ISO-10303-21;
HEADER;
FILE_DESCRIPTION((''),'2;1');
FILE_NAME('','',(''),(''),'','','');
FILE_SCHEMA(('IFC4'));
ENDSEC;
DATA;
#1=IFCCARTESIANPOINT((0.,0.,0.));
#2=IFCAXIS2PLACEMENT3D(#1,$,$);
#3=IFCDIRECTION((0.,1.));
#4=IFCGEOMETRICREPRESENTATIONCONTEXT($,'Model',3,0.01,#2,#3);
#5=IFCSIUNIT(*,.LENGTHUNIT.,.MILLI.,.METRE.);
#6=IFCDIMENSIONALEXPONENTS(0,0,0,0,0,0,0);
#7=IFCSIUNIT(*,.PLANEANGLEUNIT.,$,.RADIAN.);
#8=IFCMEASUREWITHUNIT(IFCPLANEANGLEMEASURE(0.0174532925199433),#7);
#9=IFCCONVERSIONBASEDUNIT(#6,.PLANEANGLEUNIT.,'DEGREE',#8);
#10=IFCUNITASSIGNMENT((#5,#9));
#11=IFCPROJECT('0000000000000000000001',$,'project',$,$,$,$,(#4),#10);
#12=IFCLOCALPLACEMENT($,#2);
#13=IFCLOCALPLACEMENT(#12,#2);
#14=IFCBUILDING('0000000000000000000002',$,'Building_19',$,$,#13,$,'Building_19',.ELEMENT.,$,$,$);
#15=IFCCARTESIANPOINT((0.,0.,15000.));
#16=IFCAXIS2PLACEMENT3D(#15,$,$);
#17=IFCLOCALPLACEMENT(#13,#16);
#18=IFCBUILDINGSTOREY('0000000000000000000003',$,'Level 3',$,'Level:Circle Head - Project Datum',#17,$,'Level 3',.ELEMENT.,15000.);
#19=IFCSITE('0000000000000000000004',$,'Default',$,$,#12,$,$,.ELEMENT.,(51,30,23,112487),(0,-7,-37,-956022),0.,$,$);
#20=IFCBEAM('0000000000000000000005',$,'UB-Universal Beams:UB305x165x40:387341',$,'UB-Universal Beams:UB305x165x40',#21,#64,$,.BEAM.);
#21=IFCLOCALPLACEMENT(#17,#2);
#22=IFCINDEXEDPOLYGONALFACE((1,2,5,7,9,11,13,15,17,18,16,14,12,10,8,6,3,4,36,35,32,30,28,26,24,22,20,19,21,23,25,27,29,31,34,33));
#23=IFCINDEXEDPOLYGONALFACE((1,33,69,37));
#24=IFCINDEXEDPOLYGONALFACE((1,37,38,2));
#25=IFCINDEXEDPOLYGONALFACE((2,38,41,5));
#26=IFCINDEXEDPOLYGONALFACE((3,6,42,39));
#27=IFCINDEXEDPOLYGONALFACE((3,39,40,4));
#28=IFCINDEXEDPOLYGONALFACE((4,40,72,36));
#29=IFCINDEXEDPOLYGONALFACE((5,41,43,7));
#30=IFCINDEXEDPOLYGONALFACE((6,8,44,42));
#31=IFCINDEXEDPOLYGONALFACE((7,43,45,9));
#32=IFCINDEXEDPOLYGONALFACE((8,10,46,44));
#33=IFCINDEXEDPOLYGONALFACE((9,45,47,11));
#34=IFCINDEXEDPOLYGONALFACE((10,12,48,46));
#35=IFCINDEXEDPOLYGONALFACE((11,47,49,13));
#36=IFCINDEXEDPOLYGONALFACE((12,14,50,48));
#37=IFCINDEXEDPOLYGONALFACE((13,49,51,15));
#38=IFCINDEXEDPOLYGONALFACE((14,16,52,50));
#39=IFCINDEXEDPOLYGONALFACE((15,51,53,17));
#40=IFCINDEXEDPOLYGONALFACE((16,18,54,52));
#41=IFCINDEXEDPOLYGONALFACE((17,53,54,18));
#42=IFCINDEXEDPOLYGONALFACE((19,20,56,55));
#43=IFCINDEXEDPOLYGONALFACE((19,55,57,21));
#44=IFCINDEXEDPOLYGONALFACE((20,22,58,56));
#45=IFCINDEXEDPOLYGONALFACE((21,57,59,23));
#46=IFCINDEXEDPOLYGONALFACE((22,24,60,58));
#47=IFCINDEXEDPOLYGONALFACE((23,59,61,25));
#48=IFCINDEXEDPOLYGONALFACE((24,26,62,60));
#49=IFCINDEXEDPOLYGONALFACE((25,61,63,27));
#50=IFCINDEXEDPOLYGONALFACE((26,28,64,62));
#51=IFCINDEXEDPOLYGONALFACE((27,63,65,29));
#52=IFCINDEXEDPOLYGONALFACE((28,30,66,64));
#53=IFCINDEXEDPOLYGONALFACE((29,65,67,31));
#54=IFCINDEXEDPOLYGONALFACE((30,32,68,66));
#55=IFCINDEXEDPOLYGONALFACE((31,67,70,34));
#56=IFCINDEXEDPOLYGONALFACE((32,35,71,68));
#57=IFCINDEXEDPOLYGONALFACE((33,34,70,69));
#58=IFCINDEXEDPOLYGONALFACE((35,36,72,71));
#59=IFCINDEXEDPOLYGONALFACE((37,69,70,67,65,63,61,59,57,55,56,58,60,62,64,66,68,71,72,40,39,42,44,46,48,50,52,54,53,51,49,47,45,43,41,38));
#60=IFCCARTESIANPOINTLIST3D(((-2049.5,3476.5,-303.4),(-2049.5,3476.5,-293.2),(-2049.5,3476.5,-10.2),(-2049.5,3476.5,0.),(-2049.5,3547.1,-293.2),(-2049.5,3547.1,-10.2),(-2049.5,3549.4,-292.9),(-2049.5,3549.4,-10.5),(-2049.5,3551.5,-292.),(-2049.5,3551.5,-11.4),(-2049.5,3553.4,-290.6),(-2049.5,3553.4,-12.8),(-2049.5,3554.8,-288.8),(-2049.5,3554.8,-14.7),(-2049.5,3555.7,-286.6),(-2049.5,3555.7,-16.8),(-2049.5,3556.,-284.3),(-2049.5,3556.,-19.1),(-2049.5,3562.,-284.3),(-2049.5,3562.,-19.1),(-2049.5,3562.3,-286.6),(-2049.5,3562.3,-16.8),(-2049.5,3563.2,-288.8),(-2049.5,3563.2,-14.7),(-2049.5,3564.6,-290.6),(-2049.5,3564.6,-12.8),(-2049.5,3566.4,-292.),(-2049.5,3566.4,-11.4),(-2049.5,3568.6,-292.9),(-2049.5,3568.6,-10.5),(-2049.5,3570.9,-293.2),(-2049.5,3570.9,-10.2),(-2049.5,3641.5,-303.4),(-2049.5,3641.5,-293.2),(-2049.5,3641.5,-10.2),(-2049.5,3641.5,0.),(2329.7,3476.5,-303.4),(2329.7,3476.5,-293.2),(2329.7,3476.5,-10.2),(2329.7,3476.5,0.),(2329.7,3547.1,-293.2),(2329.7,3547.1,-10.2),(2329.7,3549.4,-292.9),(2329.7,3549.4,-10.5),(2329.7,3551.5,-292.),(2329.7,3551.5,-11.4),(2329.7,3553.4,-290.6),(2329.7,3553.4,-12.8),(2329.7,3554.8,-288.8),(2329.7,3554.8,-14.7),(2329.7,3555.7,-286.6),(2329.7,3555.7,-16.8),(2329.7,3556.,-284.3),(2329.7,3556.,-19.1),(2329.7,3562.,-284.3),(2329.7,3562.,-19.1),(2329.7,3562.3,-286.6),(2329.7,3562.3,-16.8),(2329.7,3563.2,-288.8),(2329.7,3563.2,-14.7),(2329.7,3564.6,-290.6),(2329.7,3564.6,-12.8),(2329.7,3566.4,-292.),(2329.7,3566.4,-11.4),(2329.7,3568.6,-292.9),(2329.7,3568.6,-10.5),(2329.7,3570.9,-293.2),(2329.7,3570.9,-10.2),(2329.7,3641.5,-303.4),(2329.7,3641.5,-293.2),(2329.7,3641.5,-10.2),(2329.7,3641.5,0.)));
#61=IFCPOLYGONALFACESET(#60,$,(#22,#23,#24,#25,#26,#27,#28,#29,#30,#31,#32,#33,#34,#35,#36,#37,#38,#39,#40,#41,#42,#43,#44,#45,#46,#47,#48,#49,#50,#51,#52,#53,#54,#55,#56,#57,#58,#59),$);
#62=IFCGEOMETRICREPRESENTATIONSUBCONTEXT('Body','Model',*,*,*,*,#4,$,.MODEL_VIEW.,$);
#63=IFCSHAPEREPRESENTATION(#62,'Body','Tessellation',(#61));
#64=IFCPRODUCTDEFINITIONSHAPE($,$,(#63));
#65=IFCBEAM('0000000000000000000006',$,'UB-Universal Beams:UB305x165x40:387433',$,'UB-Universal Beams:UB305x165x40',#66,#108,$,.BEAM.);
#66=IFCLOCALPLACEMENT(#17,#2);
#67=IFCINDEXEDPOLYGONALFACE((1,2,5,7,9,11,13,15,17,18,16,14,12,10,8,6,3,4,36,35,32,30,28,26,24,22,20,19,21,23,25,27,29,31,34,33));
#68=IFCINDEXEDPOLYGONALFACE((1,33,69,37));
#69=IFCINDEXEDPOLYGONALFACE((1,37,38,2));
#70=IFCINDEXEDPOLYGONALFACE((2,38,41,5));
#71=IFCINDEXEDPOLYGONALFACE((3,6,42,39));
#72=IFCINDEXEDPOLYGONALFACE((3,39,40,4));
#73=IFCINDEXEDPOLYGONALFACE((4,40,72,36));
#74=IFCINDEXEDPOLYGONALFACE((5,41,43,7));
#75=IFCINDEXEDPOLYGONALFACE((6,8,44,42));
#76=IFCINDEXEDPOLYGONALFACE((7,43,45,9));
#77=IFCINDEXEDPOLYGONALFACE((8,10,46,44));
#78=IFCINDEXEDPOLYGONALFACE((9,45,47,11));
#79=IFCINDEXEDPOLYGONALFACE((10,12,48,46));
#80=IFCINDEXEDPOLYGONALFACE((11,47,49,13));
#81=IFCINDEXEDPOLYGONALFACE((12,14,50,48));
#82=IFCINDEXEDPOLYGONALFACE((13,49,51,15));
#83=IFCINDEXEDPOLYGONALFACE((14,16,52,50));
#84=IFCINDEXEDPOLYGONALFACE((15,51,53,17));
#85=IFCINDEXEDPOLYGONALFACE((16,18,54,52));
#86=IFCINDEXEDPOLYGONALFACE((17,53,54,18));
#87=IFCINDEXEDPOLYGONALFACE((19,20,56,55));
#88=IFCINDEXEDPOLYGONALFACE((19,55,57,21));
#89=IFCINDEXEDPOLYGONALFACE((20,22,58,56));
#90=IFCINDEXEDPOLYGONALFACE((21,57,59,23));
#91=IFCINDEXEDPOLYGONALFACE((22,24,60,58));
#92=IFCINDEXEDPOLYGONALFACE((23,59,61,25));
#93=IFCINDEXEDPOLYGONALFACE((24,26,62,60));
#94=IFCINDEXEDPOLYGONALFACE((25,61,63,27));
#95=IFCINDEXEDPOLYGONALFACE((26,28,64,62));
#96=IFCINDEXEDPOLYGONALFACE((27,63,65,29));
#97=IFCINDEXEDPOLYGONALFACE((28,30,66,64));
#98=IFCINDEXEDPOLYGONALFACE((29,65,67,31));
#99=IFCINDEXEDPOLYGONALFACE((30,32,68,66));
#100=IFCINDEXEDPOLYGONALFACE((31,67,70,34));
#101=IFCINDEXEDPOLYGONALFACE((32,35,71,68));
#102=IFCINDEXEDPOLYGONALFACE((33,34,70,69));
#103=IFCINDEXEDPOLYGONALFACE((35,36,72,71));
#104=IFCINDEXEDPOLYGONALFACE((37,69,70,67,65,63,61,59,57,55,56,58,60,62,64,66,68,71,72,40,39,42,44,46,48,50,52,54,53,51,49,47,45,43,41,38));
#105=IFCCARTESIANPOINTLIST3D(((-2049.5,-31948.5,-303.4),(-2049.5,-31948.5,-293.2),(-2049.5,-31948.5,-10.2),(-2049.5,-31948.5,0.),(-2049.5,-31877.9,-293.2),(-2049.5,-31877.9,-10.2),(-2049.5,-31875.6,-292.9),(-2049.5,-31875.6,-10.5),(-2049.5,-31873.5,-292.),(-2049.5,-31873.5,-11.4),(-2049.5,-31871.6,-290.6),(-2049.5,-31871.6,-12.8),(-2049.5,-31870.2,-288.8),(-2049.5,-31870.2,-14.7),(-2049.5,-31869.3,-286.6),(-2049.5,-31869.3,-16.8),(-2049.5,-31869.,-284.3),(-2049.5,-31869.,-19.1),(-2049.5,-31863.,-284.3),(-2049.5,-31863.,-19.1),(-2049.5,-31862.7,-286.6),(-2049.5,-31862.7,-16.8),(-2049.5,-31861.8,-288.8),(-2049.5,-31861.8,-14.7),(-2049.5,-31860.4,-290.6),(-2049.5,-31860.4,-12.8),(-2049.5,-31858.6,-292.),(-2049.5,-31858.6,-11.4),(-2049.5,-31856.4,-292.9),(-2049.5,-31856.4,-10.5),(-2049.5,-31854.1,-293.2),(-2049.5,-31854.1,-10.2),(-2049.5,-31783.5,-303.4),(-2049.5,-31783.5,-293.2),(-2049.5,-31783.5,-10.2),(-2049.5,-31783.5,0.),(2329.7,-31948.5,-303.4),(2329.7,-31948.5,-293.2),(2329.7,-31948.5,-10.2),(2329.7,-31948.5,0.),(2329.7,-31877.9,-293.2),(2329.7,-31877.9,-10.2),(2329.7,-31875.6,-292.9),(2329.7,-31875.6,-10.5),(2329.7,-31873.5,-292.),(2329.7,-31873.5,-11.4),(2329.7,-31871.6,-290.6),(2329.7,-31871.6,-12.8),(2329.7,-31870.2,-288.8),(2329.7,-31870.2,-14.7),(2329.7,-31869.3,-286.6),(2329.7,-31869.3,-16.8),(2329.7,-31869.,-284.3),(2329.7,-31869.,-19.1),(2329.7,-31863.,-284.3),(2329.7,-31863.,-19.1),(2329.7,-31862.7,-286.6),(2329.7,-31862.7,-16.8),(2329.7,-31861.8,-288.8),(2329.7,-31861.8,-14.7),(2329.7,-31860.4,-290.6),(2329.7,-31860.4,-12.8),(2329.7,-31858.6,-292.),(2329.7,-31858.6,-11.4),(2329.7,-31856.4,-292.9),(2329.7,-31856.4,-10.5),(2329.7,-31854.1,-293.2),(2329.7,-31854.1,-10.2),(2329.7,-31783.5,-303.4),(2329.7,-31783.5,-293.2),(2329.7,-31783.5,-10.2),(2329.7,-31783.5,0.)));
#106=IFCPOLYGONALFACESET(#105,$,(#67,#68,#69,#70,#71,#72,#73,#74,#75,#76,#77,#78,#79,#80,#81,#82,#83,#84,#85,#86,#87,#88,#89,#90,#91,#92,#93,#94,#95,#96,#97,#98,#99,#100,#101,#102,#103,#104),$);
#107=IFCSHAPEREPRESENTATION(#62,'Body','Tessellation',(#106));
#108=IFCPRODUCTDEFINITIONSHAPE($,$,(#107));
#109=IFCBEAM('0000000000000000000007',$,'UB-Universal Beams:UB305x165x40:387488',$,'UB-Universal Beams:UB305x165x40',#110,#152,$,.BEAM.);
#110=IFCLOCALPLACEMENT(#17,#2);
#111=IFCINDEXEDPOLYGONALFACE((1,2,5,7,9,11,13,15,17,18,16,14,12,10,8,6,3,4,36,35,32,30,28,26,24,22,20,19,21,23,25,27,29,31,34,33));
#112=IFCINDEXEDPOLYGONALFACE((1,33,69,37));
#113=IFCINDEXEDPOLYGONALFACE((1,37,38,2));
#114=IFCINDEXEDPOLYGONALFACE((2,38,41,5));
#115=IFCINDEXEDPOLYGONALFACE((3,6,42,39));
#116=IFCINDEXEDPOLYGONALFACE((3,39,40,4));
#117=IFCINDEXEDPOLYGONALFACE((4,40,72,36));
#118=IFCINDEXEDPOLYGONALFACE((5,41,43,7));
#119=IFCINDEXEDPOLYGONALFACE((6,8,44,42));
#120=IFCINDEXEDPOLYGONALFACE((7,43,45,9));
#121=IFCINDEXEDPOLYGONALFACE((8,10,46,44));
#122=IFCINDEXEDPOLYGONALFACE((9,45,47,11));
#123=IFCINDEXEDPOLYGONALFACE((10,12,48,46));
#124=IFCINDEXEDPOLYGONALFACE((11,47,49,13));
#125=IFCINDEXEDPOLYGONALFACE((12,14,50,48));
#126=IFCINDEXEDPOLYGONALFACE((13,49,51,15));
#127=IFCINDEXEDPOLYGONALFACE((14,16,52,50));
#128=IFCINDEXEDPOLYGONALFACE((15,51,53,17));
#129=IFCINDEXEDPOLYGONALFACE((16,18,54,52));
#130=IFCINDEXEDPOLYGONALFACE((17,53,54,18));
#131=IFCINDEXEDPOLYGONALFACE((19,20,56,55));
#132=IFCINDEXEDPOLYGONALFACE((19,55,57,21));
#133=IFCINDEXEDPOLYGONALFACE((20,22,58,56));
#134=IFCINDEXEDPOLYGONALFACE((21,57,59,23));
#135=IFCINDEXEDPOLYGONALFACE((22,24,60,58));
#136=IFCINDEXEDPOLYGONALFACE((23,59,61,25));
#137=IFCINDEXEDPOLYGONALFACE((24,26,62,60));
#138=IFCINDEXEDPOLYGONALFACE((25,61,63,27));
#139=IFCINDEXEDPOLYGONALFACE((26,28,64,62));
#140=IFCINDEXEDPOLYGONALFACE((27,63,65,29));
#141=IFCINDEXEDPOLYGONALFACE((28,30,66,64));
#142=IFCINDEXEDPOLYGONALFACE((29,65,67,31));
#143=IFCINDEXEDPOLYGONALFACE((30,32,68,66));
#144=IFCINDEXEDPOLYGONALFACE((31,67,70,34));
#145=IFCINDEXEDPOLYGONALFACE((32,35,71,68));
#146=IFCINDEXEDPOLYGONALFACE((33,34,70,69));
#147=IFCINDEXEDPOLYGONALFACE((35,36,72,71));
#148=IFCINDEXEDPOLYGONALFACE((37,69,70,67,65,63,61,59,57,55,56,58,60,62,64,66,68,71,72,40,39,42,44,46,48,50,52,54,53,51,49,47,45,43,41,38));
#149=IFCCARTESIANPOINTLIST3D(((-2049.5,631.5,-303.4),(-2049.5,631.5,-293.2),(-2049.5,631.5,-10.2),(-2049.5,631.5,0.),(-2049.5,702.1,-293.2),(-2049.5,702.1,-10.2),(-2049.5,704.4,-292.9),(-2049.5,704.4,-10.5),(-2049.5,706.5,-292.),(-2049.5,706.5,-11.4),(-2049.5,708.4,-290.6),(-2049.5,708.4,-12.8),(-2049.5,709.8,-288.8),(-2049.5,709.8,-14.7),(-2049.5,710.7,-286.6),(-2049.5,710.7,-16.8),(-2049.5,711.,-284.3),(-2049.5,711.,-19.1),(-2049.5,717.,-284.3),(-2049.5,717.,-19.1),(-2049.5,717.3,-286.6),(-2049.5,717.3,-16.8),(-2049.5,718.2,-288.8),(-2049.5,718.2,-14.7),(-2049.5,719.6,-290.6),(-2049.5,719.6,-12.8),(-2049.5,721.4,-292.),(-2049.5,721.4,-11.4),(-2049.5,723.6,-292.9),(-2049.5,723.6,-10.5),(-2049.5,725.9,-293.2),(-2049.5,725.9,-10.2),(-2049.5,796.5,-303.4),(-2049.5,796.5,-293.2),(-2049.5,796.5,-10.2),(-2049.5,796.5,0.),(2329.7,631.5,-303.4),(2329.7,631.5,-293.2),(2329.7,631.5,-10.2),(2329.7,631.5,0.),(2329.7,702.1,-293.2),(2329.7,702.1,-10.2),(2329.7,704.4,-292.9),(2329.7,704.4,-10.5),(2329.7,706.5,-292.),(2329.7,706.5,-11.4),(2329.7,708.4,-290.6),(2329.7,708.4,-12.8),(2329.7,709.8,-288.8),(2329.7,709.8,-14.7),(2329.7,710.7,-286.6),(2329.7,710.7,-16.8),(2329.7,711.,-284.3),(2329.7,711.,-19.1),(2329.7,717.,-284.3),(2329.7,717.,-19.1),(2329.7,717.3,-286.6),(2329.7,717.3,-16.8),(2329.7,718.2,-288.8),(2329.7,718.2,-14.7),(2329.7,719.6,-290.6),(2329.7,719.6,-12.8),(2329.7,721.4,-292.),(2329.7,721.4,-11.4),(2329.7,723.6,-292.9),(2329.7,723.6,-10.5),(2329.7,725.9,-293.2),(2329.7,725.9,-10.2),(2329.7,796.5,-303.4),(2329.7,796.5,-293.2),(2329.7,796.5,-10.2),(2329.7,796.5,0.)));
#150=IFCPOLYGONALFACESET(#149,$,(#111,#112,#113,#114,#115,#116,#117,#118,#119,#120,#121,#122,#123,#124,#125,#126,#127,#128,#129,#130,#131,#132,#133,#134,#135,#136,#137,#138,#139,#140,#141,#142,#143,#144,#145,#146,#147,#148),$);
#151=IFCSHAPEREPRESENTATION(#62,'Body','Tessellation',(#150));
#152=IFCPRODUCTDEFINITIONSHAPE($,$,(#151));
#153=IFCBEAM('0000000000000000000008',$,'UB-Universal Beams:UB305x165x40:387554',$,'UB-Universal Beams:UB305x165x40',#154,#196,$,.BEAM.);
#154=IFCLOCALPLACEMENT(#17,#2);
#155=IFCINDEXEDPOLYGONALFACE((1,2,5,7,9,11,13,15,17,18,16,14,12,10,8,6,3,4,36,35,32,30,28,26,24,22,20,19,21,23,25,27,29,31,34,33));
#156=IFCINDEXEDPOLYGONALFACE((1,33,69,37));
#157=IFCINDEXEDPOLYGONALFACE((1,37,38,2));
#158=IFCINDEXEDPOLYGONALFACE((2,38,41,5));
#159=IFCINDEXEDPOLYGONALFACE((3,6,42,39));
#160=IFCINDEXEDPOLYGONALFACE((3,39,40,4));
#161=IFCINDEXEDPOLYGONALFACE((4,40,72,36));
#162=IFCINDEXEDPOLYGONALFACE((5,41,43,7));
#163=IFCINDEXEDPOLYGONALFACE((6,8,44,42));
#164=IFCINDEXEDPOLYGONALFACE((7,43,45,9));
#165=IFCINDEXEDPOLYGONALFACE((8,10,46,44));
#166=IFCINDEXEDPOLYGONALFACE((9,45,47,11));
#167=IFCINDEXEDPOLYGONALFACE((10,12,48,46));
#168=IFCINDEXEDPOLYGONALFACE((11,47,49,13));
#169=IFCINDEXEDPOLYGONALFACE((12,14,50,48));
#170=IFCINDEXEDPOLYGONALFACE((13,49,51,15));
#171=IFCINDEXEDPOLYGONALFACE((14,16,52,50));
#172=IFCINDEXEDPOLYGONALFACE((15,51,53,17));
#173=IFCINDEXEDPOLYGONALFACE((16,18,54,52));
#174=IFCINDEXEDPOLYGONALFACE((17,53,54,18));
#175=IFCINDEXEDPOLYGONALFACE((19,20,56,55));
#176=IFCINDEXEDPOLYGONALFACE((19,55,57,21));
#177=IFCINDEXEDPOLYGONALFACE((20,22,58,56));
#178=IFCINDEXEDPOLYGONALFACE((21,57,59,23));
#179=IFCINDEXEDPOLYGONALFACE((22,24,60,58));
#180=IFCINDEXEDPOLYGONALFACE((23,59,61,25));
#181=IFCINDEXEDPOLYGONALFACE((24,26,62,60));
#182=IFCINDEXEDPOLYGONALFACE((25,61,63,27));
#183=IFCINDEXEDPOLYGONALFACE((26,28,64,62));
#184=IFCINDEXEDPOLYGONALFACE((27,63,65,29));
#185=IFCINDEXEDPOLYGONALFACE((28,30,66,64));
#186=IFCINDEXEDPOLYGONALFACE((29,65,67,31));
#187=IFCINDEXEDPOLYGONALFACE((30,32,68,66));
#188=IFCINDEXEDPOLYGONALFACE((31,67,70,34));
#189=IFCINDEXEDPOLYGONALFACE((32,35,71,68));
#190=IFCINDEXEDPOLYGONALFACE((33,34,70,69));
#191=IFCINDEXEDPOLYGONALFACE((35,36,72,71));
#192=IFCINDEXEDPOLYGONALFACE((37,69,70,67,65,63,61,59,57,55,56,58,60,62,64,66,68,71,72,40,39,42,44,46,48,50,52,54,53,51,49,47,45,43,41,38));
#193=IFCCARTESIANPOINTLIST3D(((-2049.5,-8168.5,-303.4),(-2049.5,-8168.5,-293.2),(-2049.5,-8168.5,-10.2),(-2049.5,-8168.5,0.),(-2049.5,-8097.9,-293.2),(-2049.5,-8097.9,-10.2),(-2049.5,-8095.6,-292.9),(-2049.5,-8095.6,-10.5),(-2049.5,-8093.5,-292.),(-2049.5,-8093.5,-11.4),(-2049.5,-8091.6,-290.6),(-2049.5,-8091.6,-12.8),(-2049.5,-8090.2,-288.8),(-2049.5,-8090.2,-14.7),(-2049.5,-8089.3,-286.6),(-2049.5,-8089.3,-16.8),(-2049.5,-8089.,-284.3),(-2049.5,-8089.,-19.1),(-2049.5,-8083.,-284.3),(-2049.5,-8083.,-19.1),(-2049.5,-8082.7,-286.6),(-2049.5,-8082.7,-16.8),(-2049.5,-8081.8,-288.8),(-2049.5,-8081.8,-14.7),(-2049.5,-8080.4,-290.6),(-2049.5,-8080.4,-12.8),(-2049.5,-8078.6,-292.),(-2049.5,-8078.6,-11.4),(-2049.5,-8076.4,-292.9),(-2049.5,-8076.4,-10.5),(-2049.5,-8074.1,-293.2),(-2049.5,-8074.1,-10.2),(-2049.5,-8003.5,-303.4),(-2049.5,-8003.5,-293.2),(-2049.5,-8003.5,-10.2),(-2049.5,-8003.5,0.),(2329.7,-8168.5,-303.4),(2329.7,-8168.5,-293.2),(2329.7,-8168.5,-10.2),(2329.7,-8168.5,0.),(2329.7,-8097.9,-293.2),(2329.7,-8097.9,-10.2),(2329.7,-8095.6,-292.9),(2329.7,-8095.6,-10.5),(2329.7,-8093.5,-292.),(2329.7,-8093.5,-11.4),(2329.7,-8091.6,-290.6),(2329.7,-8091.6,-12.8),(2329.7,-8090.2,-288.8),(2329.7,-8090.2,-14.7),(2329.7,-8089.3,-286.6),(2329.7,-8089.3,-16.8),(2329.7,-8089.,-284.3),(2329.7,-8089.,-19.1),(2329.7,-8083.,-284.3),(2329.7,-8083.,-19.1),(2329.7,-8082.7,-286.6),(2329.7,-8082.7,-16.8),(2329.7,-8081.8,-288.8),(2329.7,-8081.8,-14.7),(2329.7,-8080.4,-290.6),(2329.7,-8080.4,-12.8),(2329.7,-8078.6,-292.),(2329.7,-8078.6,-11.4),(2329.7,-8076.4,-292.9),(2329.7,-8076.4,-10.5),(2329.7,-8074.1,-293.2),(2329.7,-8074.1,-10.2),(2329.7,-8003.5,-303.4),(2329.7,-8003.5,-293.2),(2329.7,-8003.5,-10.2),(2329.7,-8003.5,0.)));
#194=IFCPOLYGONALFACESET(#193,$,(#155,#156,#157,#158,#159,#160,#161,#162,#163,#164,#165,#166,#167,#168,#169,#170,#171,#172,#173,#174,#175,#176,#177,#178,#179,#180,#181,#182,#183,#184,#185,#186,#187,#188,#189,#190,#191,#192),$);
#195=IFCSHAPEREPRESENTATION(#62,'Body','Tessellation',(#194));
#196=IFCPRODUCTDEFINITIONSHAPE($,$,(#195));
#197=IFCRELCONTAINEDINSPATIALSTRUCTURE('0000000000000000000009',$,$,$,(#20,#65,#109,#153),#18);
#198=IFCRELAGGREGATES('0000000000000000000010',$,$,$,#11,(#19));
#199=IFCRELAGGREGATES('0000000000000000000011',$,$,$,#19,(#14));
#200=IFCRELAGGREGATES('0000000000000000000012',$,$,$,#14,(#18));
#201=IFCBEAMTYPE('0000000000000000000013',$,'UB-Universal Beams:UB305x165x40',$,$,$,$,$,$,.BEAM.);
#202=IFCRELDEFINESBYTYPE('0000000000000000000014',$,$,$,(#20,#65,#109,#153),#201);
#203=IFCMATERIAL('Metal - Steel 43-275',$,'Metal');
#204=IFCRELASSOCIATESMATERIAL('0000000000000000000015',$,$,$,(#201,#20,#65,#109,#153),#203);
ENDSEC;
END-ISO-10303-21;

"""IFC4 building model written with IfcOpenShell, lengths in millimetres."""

from ifc_helpers import new_model, entity, si_unit, converted_unit, direction, frame, origin, place, context, subcontext, project, spatial, line, arc, indexed_curve, outline, extrude, source, transform, mapped, material, type_object, type_shapes, element, save


model = new_model("IFC4")

# Units and contexts
model_context = context("Model", 3, precision=0.01, world=origin(), true_north=direction((0.0, 1.0)))
body_context = subcontext(model_context, "Body", "Model", "MODEL_VIEW")
ifc_project = project(units=[si_unit("LENGTHUNIT", "METRE", prefix="MILLI"), converted_unit("PLANEANGLEUNIT", "DEGREE", entity("IfcPlaneAngleMeasure", 0.0174532925199433), si_unit("PLANEANGLEUNIT", "RADIAN"), dimensions=[0, 0, 0, 0, 0, 0, 0])], contexts=[model_context])

# Site, building, storey
site_placement = place(None, origin())
site = spatial("IfcSite", under=ifc_project, at=site_placement, Name="Default", CompositionType="ELEMENT", RefLatitude=(51, 30, 23, 112487), RefLongitude=(0, -7, -37, -956022), RefElevation=0.0)
building_placement = place(site_placement, origin())
building = spatial("IfcBuilding", under=site, at=building_placement, Name="Building_19", LongName="Building_19", CompositionType="ELEMENT")
storey_placement = place(building_placement, frame((0.0, 0.0, 15000.0)))
storey = spatial("IfcBuildingStorey", under=building, at=storey_placement, Name="Level 3", ObjectType="Level:Circle Head - Project Datum", LongName="Level 3", CompositionType="ELEMENT", Elevation=15000.0)

# Beams
ifc_material_1 = material(Name="Metal - Steel 43-275", Category="Metal")
beam_type_1 = type_object("IfcBeamType", Name="UB-Universal Beams:UB305x165x40", PredefinedType="BEAM", material=ifc_material_1)
shared_shape_1 = source(origin(), body_context, "Body", "SweptSolid", [
    extrude(outline(indexed_curve([(-82.5, -141.5), (-82.5, -151.7), (82.5, -151.7), (82.5, -141.5), (11.9, -141.5), (5.6, -138.9), (3.0, -132.6), (3.0, 132.6), (5.6, 138.9), (11.9, 141.5), (82.5, 141.5), (82.5, 151.7), (-82.5, 151.7), (-82.5, 141.5), (-11.9, 141.5), (-5.6, 138.9), (-3.0, 132.6), (-3.0, -132.6), (-5.6, -138.9), (-11.9, -141.5)], segments=[line(1, 2, 3, 4, 5), arc(5, 6, 7), line(7, 8), arc(8, 9, 10), line(10, 11, 12, 13, 14, 15), arc(15, 16, 17), line(17, 18), arc(18, 19, 20), line(20, 1)], self_intersect=False)), frame((-2189.6, 0.0, 0.0), z_axis=(-1.0, 0.0, 0.0), x_axis=(0.0, -1.0, 0.0)), (0.0, 0.0, -1.0), 4379.2),
])
type_shapes(beam_type_1, [shared_shape_1])
beam_1_placement = place(storey_placement, frame((140.1, 3559.0, -151.7)))
element("IfcBeam", 1, at=beam_1_placement, inside=storey, type_object=beam_type_1, material=ifc_material_1, Name="UB-Universal Beams:UB305x165x40:387341", ObjectType="UB-Universal Beams:UB305x165x40", PredefinedType="BEAM", context=body_context, shape_type="MappedRepresentation", body=[
    mapped(shared_shape_1, transform((0.0, 0.0, 0.0), scale=1.0)),
])
beam_2_placement = place(storey_placement, frame((140.1, -31866.0, -151.7), z_axis=(0.0, 0.0, 1.0), x_axis=(-1.0, 0.0, 0.0)))
element("IfcBeam", 2, at=beam_2_placement, inside=storey, type_object=beam_type_1, material=ifc_material_1, Name="UB-Universal Beams:UB305x165x40:387433", ObjectType="UB-Universal Beams:UB305x165x40", PredefinedType="BEAM", context=body_context, shape_type="MappedRepresentation", body=[
    mapped(shared_shape_1, transform((0.0, 0.0, 0.0), scale=1.0)),
])
for number, where, name in (
    (3, (140.1, 714.0, -151.7), "UB-Universal Beams:UB305x165x40:387488"),
    (4, (140.1, -8086.0, -151.7), "UB-Universal Beams:UB305x165x40:387554"),
):
    element("IfcBeam", number, at=place(storey_placement, frame(where)), inside=storey, type_object=beam_type_1, material=ifc_material_1, Name=name, ObjectType="UB-Universal Beams:UB305x165x40", PredefinedType="BEAM", context=body_context, shape_type="MappedRepresentation", body=[
        mapped(shared_shape_1, transform((0.0, 0.0, 0.0), scale=1.0)),
    ])

save(model, "model.ifc")
